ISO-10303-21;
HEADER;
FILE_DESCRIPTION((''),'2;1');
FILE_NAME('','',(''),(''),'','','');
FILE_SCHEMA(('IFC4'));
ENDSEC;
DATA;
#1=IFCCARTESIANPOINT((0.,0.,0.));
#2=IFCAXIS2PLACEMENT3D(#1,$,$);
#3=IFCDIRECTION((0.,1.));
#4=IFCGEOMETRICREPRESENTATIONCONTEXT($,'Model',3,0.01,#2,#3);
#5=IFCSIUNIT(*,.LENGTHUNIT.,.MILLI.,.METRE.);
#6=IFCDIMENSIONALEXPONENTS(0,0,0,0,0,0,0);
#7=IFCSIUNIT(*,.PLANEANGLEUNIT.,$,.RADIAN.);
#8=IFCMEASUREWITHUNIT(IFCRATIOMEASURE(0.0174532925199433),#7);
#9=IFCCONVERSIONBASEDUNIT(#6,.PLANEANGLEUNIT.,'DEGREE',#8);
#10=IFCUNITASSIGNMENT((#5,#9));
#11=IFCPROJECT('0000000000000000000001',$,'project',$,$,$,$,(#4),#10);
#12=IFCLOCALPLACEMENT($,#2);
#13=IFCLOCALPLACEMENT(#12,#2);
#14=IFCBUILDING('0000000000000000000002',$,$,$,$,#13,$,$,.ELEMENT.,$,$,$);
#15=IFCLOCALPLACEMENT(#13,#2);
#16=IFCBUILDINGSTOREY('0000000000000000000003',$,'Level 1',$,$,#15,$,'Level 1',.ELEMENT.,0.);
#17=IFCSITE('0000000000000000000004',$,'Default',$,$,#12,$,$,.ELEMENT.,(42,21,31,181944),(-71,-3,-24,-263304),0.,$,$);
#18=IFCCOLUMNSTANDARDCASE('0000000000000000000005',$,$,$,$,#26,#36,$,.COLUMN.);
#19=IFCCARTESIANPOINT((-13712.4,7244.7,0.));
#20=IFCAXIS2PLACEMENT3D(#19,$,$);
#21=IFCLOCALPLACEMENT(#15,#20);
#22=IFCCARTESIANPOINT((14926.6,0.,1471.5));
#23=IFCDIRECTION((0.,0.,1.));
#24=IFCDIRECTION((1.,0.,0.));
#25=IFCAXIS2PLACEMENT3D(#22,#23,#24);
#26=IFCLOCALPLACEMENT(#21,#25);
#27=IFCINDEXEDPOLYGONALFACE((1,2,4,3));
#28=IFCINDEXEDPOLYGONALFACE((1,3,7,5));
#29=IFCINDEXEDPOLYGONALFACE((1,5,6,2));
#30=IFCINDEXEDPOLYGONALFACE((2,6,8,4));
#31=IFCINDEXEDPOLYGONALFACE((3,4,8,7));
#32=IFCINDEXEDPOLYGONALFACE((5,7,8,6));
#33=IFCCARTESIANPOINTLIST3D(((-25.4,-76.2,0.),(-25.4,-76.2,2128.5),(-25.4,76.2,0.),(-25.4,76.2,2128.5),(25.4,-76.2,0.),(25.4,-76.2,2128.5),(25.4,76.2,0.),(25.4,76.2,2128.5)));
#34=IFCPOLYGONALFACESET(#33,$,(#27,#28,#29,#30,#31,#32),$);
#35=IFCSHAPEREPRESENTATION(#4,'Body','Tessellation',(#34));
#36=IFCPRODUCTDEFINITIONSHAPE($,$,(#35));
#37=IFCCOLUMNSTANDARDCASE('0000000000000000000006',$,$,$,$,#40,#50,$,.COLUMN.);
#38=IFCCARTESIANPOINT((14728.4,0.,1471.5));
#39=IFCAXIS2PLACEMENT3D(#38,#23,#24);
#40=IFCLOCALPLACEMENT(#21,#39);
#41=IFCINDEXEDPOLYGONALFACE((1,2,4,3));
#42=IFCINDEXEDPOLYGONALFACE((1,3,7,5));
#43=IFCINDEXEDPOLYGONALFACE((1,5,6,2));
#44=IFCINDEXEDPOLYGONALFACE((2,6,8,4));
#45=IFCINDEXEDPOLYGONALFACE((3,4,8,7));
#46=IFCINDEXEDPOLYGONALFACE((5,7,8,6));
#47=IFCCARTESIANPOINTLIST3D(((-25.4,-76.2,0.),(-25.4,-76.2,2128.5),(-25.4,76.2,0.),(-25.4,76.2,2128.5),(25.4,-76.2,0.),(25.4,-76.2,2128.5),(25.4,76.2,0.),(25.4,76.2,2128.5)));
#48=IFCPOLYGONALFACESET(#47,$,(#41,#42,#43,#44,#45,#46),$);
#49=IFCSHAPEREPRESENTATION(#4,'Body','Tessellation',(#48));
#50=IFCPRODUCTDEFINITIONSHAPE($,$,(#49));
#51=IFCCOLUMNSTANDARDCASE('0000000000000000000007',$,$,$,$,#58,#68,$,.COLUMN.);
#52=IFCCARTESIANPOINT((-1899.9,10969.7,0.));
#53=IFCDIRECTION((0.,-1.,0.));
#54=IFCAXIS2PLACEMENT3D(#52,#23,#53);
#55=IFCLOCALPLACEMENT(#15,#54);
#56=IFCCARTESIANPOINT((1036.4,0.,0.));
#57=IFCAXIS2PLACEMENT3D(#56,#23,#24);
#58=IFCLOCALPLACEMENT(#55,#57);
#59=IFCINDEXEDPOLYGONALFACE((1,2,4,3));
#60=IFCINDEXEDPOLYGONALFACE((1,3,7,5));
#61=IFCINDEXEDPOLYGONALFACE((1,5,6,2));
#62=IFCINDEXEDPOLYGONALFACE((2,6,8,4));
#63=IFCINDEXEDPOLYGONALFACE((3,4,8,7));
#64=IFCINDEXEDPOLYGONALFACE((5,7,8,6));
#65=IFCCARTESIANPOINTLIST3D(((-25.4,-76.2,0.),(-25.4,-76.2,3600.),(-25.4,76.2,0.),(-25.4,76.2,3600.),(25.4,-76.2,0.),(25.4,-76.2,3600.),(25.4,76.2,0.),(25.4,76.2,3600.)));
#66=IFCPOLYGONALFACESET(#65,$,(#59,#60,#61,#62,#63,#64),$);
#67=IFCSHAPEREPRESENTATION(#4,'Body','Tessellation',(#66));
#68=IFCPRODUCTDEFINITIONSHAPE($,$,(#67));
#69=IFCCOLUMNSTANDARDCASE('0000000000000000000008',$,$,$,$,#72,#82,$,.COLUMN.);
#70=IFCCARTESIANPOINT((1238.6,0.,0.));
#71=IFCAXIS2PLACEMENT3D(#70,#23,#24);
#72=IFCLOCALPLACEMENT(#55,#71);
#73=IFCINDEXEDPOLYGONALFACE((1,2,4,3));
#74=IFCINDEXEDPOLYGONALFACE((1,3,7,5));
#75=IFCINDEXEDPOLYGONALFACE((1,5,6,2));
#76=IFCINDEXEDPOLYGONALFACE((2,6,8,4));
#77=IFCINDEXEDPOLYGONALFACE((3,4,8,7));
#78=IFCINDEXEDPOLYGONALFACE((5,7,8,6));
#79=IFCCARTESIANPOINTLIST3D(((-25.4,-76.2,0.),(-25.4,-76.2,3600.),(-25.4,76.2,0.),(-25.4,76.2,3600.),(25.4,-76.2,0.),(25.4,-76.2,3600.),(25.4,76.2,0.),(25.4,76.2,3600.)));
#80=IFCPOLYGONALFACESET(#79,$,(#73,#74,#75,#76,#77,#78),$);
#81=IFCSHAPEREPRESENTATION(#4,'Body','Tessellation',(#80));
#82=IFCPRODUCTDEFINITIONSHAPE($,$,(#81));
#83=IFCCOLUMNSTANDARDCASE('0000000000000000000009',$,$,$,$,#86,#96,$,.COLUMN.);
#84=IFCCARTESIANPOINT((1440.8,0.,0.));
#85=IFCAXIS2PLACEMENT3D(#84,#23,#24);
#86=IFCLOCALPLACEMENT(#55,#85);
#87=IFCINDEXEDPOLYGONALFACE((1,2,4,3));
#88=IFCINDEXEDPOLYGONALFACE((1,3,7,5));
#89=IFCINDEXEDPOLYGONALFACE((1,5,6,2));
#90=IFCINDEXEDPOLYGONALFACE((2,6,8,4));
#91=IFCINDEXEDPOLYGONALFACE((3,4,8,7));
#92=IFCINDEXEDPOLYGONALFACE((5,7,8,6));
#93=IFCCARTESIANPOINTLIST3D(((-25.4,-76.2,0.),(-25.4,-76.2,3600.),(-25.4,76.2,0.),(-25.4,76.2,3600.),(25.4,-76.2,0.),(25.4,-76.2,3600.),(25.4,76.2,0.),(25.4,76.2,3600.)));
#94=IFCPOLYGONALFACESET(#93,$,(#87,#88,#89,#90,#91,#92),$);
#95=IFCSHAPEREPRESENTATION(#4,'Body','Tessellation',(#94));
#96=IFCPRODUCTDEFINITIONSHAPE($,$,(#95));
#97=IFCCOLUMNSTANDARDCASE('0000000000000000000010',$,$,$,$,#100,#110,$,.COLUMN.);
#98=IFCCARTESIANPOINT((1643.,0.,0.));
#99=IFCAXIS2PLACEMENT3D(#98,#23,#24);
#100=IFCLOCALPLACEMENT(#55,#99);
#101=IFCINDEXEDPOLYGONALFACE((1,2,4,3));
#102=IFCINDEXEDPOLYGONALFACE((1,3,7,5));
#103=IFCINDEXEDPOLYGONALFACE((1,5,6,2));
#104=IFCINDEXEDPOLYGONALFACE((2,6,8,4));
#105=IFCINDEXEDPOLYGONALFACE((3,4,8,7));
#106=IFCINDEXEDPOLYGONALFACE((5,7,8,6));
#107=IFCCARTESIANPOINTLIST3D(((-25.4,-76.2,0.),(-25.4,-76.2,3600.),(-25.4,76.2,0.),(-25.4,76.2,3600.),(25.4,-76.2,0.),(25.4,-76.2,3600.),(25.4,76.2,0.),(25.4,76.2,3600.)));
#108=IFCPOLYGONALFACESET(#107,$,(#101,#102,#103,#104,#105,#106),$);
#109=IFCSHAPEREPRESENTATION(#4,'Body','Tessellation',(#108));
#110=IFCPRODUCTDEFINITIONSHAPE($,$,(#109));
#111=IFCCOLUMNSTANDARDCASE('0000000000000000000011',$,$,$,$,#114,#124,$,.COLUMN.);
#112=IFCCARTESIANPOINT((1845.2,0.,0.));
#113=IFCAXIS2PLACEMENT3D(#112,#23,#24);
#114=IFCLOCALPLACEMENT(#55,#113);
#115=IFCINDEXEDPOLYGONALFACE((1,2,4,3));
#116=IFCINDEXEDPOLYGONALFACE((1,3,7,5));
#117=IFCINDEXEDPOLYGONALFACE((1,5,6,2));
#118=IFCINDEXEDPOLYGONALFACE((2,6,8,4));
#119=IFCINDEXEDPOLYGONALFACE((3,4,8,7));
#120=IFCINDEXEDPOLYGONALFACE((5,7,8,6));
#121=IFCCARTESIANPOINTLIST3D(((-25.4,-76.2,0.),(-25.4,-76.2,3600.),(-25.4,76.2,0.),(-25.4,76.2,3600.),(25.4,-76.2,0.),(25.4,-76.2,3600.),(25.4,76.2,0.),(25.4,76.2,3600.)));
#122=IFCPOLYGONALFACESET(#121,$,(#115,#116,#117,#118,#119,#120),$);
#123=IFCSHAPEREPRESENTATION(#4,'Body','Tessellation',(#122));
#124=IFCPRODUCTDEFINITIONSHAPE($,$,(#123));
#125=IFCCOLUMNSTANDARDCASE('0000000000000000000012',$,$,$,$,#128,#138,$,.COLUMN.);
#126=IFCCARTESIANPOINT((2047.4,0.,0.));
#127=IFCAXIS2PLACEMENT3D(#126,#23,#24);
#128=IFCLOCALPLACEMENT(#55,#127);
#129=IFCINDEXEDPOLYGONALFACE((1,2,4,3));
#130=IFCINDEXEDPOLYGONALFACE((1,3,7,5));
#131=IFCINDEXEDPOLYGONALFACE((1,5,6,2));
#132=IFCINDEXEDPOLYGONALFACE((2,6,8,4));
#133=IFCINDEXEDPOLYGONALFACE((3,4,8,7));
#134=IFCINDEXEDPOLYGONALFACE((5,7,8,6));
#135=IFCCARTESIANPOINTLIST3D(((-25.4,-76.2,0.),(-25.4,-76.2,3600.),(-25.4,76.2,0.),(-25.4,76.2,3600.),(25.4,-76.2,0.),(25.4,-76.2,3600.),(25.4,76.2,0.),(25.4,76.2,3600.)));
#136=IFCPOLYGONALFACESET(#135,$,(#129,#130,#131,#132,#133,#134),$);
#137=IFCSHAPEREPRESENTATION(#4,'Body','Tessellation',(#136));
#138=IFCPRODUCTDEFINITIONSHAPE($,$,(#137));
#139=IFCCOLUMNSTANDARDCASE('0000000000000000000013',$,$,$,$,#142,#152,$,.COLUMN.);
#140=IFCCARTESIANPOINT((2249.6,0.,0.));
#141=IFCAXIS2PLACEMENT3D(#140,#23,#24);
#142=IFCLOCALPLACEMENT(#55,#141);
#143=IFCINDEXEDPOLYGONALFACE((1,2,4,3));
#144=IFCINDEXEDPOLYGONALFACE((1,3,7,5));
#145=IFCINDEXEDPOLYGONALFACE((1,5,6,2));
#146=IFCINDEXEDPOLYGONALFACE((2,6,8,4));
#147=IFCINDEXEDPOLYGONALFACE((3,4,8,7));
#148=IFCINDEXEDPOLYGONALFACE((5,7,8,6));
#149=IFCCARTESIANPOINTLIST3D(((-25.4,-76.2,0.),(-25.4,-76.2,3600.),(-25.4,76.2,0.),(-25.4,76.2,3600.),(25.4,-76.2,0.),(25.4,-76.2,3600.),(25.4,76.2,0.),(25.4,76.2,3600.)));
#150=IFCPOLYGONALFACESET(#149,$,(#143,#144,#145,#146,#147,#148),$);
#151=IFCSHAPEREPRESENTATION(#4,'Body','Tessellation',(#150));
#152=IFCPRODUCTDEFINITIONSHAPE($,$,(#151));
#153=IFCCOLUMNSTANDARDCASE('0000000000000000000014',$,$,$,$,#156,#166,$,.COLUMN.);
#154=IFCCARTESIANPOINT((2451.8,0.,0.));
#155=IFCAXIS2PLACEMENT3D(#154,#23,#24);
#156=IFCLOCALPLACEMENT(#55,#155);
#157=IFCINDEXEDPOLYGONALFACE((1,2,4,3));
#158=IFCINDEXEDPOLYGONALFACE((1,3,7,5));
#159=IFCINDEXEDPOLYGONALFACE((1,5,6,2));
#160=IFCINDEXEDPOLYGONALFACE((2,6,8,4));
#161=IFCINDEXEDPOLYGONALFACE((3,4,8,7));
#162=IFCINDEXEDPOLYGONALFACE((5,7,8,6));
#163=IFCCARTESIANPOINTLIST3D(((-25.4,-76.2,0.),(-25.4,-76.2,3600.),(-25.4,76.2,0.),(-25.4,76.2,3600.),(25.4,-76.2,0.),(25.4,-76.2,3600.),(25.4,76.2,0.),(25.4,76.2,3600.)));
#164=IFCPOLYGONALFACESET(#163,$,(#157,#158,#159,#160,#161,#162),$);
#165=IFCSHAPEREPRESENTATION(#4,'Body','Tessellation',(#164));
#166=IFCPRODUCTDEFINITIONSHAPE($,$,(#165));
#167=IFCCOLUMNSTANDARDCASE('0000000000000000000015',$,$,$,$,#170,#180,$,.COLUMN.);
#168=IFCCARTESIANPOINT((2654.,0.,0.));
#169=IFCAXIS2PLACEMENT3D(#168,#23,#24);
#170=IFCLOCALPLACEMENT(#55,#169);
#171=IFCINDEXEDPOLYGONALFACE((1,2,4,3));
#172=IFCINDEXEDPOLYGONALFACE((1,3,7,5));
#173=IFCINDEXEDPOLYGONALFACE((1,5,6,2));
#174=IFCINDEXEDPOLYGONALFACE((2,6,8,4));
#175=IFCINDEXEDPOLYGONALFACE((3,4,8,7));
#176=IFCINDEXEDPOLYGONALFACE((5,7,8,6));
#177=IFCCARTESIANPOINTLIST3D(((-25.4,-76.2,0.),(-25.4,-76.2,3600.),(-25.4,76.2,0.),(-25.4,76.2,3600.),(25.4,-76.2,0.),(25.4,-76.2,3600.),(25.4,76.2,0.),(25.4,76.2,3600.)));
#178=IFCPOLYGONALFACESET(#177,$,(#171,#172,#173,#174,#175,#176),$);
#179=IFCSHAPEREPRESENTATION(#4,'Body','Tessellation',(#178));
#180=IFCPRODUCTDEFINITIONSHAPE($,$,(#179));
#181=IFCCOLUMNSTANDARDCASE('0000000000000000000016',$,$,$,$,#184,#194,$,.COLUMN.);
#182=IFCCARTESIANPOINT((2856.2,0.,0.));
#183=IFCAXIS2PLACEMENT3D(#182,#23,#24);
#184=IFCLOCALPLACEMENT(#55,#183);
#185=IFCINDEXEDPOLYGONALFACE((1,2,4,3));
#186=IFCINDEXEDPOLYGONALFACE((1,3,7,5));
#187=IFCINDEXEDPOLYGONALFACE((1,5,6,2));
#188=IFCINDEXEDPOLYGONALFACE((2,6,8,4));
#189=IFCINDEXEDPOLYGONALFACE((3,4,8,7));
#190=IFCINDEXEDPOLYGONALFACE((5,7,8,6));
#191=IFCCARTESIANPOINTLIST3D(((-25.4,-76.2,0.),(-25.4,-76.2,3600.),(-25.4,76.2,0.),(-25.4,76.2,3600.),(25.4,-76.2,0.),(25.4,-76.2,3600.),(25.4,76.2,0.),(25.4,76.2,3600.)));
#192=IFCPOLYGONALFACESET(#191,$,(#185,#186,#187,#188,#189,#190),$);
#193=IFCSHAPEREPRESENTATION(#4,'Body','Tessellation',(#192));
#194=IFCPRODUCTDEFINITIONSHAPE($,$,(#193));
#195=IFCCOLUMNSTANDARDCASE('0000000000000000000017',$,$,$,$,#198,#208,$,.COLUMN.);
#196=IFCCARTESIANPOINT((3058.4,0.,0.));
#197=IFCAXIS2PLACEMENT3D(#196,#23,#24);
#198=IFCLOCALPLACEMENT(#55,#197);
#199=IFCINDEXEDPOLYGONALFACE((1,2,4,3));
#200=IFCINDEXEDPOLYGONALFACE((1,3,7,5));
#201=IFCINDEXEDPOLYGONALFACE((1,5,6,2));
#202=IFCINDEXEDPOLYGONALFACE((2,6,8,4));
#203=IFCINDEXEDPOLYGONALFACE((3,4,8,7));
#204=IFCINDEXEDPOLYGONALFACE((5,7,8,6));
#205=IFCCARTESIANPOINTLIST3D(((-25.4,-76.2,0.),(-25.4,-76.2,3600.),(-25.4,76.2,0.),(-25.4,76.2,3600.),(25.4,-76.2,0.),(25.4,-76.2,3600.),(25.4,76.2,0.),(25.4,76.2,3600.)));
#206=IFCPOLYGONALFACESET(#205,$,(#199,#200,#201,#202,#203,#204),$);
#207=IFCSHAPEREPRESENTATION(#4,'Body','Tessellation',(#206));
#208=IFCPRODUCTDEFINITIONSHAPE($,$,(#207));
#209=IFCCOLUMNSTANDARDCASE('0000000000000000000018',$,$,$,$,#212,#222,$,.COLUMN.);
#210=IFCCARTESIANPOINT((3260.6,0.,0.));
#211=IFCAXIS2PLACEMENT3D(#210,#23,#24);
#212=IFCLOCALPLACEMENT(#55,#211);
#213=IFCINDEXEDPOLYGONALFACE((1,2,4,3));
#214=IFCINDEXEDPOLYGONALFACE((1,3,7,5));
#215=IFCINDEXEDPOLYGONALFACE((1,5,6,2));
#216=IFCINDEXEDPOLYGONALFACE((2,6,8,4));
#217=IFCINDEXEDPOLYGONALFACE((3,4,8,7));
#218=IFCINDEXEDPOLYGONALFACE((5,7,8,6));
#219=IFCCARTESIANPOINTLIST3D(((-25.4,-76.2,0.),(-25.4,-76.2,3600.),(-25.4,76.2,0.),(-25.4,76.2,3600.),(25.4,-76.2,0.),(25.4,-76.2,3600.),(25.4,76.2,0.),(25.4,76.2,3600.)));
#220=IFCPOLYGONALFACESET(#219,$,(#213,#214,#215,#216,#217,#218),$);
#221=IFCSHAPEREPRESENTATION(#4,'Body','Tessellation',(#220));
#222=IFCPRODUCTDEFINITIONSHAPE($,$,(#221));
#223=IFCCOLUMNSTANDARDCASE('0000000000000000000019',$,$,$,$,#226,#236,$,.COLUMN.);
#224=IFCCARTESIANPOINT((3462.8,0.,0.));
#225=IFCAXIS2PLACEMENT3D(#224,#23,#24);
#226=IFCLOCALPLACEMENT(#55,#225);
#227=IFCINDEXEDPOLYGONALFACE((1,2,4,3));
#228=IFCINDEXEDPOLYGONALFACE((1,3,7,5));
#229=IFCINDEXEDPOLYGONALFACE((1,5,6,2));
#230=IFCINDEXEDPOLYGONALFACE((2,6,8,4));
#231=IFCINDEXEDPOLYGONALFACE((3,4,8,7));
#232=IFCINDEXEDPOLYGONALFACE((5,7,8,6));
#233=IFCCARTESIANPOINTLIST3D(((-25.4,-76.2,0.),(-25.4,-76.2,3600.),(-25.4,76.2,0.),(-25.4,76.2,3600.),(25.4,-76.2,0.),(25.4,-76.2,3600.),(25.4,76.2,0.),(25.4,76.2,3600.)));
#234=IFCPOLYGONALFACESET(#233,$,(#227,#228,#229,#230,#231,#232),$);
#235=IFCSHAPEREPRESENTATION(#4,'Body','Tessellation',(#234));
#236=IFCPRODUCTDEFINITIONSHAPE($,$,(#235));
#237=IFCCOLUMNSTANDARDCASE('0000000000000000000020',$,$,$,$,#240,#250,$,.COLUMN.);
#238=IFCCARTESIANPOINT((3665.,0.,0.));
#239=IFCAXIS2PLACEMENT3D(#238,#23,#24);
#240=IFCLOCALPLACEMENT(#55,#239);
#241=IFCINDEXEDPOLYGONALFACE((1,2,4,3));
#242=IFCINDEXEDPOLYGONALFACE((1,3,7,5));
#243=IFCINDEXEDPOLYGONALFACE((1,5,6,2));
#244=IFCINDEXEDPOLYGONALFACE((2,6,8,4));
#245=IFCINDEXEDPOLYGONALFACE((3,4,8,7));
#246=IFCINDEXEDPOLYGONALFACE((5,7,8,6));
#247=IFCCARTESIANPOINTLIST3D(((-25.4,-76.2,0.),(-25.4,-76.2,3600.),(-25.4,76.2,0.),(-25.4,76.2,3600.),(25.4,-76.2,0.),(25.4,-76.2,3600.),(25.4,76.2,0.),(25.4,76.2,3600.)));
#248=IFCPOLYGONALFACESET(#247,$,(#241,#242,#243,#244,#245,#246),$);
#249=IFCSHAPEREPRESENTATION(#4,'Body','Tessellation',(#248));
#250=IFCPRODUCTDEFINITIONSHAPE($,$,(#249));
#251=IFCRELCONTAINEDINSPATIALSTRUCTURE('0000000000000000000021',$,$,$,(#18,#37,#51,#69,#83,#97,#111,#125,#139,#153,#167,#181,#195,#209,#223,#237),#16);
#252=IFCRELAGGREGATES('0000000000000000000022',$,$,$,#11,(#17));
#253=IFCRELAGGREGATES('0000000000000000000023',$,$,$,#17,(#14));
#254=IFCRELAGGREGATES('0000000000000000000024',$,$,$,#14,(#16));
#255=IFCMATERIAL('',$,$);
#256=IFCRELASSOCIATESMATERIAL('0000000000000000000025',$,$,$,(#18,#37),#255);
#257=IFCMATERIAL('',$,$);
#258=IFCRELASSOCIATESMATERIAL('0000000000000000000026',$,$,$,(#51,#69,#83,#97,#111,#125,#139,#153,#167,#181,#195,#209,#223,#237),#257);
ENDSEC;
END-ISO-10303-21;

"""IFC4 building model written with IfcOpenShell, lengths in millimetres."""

from ifc_helpers import new_model, entity, si_unit, converted_unit, direction, frame, origin, place, context, project, spatial, rectangle, extrude, material, element, save


model = new_model("IFC4")

# Units and contexts
model_context = context("Model", 3, precision=0.01, world=origin(), true_north=direction((0.0, 1.0)))
ifc_project = project(units=[si_unit("LENGTHUNIT", "METRE", prefix="MILLI"), converted_unit("PLANEANGLEUNIT", "DEGREE", entity("IfcRatioMeasure", 0.0174532925199433), si_unit("PLANEANGLEUNIT", "RADIAN"), dimensions=[0, 0, 0, 0, 0, 0, 0])], contexts=[model_context])

# Site, building, storey
site_placement = place(None, origin())
site = spatial("IfcSite", under=ifc_project, at=site_placement, Name="Default", CompositionType="ELEMENT", RefLatitude=(42, 21, 31, 181944), RefLongitude=(-71, -3, -24, -263304), RefElevation=0.0)
building_placement = place(site_placement, origin())
building = spatial("IfcBuilding", under=site, at=building_placement, CompositionType="ELEMENT")
storey_placement = place(building_placement, origin())
storey = spatial("IfcBuildingStorey", under=building, at=storey_placement, Name="Level 1", LongName="Level 1", CompositionType="ELEMENT", Elevation=0.0)

# Columns
ifc_material_1 = material(Name="")
placement_1 = place(storey_placement, frame((-13712.4, 7244.7, 0.0)))
for number, where, z_axis, x_axis in (
    (1, (14926.6, 0.0, 1471.5), (0.0, 0.0, 1.0), (1.0, 0.0, 0.0)),
    (2, (14728.4, 0.0, 1471.5), (0.0, 0.0, 1.0), (1.0, 0.0, 0.0)),
):
    element("IfcColumnStandardCase", number, at=place(placement_1, frame(where, z_axis=z_axis, x_axis=x_axis)), inside=storey, material=ifc_material_1, PredefinedType="COLUMN", context=model_context, shape_type="SweptSolid", body=[
        extrude(rectangle(XDim=50.8, YDim=152.4), origin(), (0.0, 0.0, 1.0), 2128.5),
    ])
ifc_material_2 = material(Name="")
placement_2 = place(storey_placement, frame((-1899.9, 10969.7, 0.0), z_axis=(0.0, 0.0, 1.0), x_axis=(0.0, -1.0, 0.0)))
for number, where, z_axis, x_axis in (
    (3, (1036.4, 0.0, 0.0), (0.0, 0.0, 1.0), (1.0, 0.0, 0.0)),
    (4, (1238.6, 0.0, 0.0), (0.0, 0.0, 1.0), (1.0, 0.0, 0.0)),
    (5, (1440.8, 0.0, 0.0), (0.0, 0.0, 1.0), (1.0, 0.0, 0.0)),
    (6, (1643.0, 0.0, 0.0), (0.0, 0.0, 1.0), (1.0, 0.0, 0.0)),
    (7, (1845.2, 0.0, 0.0), (0.0, 0.0, 1.0), (1.0, 0.0, 0.0)),
    (8, (2047.4, 0.0, 0.0), (0.0, 0.0, 1.0), (1.0, 0.0, 0.0)),
    (9, (2249.6, 0.0, 0.0), (0.0, 0.0, 1.0), (1.0, 0.0, 0.0)),
    (10, (2451.8, 0.0, 0.0), (0.0, 0.0, 1.0), (1.0, 0.0, 0.0)),
    (11, (2654.0, 0.0, 0.0), (0.0, 0.0, 1.0), (1.0, 0.0, 0.0)),
    (12, (2856.2, 0.0, 0.0), (0.0, 0.0, 1.0), (1.0, 0.0, 0.0)),
    (13, (3058.4, 0.0, 0.0), (0.0, 0.0, 1.0), (1.0, 0.0, 0.0)),
    (14, (3260.6, 0.0, 0.0), (0.0, 0.0, 1.0), (1.0, 0.0, 0.0)),
    (15, (3462.8, 0.0, 0.0), (0.0, 0.0, 1.0), (1.0, 0.0, 0.0)),
    (16, (3665.0, 0.0, 0.0), (0.0, 0.0, 1.0), (1.0, 0.0, 0.0)),
):
    element("IfcColumnStandardCase", number, at=place(placement_2, frame(where, z_axis=z_axis, x_axis=x_axis)), inside=storey, material=ifc_material_2, PredefinedType="COLUMN", context=model_context, shape_type="SweptSolid", body=[
        extrude(rectangle(XDim=50.8, YDim=152.4), origin(), (0.0, 0.0, 1.0), 3600.0),
    ])

save(model, "model.ifc")
